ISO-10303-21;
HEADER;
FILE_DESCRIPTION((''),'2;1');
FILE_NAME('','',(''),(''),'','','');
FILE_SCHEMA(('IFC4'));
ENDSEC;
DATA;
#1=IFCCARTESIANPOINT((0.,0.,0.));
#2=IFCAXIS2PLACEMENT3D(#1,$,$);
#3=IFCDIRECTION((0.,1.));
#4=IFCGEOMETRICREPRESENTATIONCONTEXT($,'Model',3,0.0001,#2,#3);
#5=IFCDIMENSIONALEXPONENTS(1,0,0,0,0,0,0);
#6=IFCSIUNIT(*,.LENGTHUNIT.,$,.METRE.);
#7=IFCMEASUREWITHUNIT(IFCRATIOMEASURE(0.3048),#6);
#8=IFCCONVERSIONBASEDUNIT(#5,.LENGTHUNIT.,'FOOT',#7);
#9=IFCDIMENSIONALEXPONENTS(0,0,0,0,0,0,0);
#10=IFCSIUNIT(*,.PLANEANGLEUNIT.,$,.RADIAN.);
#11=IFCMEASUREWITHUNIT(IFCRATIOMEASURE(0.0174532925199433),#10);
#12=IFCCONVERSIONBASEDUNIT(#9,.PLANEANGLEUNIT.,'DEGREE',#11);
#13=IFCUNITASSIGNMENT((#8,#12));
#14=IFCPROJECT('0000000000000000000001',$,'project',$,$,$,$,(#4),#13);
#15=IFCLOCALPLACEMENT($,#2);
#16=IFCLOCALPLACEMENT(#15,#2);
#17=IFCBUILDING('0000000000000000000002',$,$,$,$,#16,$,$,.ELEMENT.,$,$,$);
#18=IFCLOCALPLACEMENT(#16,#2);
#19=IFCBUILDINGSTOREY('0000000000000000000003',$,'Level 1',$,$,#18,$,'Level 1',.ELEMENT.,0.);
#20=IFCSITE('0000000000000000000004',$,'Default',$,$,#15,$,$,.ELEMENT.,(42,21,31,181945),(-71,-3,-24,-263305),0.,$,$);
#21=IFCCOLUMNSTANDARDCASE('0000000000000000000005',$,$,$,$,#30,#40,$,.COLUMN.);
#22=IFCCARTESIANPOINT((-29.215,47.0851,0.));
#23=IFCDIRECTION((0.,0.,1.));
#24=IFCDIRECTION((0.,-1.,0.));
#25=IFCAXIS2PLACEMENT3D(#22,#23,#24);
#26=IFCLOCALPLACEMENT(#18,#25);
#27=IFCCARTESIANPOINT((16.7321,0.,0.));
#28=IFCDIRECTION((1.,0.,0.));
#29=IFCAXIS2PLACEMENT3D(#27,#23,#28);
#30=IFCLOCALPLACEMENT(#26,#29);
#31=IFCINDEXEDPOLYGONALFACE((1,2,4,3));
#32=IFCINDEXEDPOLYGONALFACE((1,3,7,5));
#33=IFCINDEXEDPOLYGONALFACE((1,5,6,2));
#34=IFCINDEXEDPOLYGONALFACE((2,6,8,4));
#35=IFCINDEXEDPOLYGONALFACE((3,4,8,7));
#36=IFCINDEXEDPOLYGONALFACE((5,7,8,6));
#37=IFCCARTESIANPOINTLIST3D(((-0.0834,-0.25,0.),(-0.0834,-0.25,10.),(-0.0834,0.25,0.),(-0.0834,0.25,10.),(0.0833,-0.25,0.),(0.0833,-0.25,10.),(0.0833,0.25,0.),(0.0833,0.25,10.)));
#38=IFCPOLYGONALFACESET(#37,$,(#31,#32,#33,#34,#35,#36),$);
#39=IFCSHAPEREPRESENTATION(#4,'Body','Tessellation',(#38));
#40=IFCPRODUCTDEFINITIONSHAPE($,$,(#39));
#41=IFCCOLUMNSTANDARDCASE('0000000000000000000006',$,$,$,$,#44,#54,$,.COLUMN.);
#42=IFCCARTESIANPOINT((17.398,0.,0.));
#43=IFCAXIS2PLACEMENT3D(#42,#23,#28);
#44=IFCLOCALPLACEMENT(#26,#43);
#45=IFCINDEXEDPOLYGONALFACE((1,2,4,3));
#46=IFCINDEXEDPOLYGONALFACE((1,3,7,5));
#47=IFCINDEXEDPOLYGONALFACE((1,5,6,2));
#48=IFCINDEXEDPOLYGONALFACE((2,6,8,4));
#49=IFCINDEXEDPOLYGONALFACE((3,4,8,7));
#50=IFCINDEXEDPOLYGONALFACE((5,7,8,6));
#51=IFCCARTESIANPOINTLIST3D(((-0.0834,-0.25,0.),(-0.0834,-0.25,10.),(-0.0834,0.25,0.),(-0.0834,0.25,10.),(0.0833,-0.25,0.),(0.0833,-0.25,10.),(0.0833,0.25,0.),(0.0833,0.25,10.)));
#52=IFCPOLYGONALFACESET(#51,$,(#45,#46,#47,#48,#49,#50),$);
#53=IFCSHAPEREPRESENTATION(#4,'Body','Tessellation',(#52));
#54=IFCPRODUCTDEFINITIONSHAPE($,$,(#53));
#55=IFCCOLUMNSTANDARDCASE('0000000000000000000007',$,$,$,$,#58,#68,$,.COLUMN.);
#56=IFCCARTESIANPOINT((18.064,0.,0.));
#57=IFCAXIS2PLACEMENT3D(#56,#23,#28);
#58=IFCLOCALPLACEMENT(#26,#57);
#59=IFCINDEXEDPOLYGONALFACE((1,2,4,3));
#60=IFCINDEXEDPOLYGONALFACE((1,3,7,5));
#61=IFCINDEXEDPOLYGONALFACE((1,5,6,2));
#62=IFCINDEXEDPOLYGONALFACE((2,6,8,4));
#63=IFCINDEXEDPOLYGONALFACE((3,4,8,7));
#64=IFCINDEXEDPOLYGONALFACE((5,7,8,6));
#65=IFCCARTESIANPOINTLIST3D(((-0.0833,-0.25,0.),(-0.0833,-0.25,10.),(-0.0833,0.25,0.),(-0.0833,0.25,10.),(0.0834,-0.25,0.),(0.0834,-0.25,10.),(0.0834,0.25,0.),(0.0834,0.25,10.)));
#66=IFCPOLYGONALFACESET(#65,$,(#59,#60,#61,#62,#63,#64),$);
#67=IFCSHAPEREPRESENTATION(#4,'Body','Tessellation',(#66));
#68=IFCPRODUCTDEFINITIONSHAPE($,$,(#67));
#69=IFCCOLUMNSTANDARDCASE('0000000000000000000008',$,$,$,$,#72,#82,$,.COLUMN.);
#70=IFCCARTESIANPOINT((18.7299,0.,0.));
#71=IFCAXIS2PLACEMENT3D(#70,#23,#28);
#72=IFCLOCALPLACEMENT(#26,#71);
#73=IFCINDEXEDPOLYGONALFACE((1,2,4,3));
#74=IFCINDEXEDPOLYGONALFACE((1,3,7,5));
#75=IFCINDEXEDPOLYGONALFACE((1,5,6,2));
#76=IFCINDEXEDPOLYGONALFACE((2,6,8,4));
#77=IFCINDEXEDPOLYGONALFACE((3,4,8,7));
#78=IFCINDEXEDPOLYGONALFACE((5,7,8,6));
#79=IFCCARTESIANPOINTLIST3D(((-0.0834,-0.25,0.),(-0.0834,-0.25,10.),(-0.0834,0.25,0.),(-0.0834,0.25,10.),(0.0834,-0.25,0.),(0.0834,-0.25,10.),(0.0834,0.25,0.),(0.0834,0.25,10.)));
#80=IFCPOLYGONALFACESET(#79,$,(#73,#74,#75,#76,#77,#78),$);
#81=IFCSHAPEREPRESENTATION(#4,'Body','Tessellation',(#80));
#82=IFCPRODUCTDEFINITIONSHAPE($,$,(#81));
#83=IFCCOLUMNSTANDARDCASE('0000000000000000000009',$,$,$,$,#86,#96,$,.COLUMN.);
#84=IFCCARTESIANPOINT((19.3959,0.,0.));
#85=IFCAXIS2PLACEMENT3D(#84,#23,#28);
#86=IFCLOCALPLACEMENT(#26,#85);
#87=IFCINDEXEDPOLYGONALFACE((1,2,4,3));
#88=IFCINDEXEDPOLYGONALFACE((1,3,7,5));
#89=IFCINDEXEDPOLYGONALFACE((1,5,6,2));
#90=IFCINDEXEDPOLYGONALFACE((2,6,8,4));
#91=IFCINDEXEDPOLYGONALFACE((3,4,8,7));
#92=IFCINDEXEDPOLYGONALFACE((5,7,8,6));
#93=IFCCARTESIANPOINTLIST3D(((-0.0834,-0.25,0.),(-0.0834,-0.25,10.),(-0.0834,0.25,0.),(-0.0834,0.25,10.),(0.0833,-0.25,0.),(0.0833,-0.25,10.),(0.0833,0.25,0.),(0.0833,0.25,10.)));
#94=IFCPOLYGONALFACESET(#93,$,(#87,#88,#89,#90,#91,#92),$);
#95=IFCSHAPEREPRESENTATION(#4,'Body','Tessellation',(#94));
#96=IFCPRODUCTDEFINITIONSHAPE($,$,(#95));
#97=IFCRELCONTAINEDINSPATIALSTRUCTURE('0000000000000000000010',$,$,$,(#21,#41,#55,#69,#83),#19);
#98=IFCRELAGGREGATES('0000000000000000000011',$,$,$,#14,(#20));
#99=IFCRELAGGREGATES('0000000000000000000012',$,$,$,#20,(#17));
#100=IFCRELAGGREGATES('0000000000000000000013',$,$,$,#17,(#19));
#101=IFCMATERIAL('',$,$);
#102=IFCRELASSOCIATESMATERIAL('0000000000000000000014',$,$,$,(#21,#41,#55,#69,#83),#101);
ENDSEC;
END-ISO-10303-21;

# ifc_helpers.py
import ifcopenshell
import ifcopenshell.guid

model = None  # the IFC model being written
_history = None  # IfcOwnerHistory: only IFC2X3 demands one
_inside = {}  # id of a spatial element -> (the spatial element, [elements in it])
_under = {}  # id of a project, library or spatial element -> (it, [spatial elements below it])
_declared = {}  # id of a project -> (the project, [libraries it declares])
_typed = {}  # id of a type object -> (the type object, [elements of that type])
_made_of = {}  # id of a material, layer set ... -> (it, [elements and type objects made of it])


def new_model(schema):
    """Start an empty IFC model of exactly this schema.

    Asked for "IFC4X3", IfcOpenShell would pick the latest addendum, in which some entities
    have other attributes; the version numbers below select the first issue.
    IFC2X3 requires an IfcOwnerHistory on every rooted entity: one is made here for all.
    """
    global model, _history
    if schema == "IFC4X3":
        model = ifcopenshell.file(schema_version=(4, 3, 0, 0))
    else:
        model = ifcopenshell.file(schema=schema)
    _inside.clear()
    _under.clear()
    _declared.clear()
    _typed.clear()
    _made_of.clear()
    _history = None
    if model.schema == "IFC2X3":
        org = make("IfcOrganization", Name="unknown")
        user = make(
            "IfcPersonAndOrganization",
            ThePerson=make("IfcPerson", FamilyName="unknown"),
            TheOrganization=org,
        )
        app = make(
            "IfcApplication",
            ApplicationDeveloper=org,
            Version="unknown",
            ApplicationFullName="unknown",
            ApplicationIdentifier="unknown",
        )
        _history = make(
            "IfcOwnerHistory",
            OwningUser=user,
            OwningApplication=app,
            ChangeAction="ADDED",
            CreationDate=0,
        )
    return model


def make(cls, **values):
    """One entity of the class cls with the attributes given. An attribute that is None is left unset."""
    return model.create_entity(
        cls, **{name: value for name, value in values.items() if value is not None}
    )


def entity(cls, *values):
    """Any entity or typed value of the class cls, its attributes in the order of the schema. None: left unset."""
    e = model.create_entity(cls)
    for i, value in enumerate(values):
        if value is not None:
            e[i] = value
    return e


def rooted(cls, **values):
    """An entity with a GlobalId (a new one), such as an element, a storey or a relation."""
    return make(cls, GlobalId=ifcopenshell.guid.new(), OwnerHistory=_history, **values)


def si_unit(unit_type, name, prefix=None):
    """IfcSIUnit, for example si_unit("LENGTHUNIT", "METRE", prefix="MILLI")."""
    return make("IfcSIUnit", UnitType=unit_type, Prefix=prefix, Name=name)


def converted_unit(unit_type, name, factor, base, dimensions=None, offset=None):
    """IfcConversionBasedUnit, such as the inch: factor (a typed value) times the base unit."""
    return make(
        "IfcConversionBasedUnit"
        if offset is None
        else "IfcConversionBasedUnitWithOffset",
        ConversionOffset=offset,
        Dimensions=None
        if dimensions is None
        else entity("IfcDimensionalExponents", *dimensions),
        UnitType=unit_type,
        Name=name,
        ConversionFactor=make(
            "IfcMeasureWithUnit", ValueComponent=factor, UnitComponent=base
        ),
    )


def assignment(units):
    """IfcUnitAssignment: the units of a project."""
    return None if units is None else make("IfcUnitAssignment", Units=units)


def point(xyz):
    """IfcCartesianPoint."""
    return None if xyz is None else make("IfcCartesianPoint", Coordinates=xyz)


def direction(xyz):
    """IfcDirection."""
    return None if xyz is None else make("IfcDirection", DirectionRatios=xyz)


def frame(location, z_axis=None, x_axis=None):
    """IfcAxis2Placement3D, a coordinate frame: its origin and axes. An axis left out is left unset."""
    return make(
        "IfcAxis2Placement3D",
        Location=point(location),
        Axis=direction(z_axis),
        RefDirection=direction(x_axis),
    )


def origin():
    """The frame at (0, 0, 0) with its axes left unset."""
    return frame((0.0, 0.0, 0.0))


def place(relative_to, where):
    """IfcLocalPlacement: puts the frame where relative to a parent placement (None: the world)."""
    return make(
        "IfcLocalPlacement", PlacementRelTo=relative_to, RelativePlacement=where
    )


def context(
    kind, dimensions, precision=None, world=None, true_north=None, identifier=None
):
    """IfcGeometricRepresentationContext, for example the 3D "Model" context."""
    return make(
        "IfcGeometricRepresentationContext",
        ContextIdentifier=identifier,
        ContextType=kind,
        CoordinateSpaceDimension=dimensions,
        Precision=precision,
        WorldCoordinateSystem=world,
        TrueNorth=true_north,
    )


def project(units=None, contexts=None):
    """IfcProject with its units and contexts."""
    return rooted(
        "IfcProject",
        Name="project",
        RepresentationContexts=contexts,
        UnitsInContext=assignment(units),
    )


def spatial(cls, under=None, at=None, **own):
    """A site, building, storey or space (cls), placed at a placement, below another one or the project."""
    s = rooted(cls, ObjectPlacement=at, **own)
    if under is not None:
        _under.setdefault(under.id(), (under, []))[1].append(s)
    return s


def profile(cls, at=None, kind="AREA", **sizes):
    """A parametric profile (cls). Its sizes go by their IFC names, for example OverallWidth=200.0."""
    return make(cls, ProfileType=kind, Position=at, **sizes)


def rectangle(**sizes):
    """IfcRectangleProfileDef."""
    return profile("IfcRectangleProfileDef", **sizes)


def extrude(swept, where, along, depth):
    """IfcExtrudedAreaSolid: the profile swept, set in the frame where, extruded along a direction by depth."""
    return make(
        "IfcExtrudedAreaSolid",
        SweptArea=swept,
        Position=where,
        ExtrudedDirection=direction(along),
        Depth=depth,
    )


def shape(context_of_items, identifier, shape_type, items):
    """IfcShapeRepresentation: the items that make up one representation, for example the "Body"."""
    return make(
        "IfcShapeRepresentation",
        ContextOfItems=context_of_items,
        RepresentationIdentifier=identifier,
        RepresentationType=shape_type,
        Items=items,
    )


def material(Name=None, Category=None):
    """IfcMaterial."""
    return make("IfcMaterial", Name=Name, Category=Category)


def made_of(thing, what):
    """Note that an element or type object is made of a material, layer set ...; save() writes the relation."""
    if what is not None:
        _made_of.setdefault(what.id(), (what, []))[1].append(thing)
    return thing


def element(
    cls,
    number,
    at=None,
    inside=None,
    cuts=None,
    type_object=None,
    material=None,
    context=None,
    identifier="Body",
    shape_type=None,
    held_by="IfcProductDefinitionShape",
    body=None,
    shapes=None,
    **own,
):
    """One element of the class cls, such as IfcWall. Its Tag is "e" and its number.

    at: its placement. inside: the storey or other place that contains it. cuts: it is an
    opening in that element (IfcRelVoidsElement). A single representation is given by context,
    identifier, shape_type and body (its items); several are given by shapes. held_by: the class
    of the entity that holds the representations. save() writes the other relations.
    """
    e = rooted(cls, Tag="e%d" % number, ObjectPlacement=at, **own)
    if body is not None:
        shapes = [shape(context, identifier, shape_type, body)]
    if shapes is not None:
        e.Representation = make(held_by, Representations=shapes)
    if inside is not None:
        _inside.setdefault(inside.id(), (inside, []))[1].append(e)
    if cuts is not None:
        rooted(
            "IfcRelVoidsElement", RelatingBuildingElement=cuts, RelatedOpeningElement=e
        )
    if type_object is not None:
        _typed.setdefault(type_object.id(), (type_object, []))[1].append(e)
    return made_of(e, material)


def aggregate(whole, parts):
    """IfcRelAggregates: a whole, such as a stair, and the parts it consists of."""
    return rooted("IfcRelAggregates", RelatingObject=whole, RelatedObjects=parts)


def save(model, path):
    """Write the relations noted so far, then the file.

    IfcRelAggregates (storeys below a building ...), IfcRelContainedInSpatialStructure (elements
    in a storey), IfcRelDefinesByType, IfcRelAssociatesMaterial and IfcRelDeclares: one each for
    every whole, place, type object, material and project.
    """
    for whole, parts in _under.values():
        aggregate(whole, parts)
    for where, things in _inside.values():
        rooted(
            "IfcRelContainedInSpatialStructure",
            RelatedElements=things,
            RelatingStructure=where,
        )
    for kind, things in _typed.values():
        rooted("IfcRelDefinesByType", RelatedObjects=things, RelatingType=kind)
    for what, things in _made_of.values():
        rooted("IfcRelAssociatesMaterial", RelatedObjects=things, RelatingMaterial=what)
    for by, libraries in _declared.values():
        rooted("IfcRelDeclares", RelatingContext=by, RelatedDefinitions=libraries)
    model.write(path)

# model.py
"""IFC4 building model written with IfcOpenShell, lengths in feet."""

from ifc_helpers import new_model, entity, si_unit, converted_unit, direction, frame, origin, place, context, project, spatial, rectangle, extrude, material, element, save


model = new_model("IFC4")

# Units and contexts
model_context = context("Model", 3, precision=0.0001, world=origin(), true_north=direction((0.0, 1.0)))
ifc_project = project(units=[converted_unit("LENGTHUNIT", "FOOT", entity("IfcRatioMeasure", 0.3048), si_unit("LENGTHUNIT", "METRE"), dimensions=[1, 0, 0, 0, 0, 0, 0]), converted_unit("PLANEANGLEUNIT", "DEGREE", entity("IfcRatioMeasure", 0.0174532925199433), si_unit("PLANEANGLEUNIT", "RADIAN"), dimensions=[0, 0, 0, 0, 0, 0, 0])], contexts=[model_context])

# Site, building, storey
site_placement = place(None, origin())
site = spatial("IfcSite", under=ifc_project, at=site_placement, Name="Default", CompositionType="ELEMENT", RefLatitude=(42, 21, 31, 181945), RefLongitude=(-71, -3, -24, -263305), RefElevation=0.0)
building_placement = place(site_placement, origin())
building = spatial("IfcBuilding", under=site, at=building_placement, CompositionType="ELEMENT")
storey_placement = place(building_placement, origin())
storey = spatial("IfcBuildingStorey", under=building, at=storey_placement, Name="Level 1", LongName="Level 1", CompositionType="ELEMENT", Elevation=0.0)

# Columns
ifc_material = material(Name="")
placement = place(storey_placement, frame((-29.215, 47.0851, 0.0), z_axis=(0.0, 0.0, 1.0), x_axis=(0.0, -1.0, 0.0)))
for number, where, z_axis, x_axis in (
    (1, (16.7321, 0.0, 0.0), (0.0, 0.0, 1.0), (1.0, 0.0, 0.0)),
    (2, (17.398, 0.0, 0.0), (0.0, 0.0, 1.0), (1.0, 0.0, 0.0)),
    (3, (18.064, 0.0, 0.0), (0.0, 0.0, 1.0), (1.0, 0.0, 0.0)),
    (4, (18.7299, 0.0, 0.0), (0.0, 0.0, 1.0), (1.0, 0.0, 0.0)),
    (5, (19.3959, 0.0, 0.0), (0.0, 0.0, 1.0), (1.0, 0.0, 0.0)),
):
    element("IfcColumnStandardCase", number, at=place(placement, frame(where, z_axis=z_axis, x_axis=x_axis)), inside=storey, material=ifc_material, PredefinedType="COLUMN", context=model_context, shape_type="SweptSolid", body=[
        extrude(rectangle(XDim=0.1667, YDim=0.5), origin(), (0.0, 0.0, 1.0), 10.0),
    ])

save(model, "model.ifc")
